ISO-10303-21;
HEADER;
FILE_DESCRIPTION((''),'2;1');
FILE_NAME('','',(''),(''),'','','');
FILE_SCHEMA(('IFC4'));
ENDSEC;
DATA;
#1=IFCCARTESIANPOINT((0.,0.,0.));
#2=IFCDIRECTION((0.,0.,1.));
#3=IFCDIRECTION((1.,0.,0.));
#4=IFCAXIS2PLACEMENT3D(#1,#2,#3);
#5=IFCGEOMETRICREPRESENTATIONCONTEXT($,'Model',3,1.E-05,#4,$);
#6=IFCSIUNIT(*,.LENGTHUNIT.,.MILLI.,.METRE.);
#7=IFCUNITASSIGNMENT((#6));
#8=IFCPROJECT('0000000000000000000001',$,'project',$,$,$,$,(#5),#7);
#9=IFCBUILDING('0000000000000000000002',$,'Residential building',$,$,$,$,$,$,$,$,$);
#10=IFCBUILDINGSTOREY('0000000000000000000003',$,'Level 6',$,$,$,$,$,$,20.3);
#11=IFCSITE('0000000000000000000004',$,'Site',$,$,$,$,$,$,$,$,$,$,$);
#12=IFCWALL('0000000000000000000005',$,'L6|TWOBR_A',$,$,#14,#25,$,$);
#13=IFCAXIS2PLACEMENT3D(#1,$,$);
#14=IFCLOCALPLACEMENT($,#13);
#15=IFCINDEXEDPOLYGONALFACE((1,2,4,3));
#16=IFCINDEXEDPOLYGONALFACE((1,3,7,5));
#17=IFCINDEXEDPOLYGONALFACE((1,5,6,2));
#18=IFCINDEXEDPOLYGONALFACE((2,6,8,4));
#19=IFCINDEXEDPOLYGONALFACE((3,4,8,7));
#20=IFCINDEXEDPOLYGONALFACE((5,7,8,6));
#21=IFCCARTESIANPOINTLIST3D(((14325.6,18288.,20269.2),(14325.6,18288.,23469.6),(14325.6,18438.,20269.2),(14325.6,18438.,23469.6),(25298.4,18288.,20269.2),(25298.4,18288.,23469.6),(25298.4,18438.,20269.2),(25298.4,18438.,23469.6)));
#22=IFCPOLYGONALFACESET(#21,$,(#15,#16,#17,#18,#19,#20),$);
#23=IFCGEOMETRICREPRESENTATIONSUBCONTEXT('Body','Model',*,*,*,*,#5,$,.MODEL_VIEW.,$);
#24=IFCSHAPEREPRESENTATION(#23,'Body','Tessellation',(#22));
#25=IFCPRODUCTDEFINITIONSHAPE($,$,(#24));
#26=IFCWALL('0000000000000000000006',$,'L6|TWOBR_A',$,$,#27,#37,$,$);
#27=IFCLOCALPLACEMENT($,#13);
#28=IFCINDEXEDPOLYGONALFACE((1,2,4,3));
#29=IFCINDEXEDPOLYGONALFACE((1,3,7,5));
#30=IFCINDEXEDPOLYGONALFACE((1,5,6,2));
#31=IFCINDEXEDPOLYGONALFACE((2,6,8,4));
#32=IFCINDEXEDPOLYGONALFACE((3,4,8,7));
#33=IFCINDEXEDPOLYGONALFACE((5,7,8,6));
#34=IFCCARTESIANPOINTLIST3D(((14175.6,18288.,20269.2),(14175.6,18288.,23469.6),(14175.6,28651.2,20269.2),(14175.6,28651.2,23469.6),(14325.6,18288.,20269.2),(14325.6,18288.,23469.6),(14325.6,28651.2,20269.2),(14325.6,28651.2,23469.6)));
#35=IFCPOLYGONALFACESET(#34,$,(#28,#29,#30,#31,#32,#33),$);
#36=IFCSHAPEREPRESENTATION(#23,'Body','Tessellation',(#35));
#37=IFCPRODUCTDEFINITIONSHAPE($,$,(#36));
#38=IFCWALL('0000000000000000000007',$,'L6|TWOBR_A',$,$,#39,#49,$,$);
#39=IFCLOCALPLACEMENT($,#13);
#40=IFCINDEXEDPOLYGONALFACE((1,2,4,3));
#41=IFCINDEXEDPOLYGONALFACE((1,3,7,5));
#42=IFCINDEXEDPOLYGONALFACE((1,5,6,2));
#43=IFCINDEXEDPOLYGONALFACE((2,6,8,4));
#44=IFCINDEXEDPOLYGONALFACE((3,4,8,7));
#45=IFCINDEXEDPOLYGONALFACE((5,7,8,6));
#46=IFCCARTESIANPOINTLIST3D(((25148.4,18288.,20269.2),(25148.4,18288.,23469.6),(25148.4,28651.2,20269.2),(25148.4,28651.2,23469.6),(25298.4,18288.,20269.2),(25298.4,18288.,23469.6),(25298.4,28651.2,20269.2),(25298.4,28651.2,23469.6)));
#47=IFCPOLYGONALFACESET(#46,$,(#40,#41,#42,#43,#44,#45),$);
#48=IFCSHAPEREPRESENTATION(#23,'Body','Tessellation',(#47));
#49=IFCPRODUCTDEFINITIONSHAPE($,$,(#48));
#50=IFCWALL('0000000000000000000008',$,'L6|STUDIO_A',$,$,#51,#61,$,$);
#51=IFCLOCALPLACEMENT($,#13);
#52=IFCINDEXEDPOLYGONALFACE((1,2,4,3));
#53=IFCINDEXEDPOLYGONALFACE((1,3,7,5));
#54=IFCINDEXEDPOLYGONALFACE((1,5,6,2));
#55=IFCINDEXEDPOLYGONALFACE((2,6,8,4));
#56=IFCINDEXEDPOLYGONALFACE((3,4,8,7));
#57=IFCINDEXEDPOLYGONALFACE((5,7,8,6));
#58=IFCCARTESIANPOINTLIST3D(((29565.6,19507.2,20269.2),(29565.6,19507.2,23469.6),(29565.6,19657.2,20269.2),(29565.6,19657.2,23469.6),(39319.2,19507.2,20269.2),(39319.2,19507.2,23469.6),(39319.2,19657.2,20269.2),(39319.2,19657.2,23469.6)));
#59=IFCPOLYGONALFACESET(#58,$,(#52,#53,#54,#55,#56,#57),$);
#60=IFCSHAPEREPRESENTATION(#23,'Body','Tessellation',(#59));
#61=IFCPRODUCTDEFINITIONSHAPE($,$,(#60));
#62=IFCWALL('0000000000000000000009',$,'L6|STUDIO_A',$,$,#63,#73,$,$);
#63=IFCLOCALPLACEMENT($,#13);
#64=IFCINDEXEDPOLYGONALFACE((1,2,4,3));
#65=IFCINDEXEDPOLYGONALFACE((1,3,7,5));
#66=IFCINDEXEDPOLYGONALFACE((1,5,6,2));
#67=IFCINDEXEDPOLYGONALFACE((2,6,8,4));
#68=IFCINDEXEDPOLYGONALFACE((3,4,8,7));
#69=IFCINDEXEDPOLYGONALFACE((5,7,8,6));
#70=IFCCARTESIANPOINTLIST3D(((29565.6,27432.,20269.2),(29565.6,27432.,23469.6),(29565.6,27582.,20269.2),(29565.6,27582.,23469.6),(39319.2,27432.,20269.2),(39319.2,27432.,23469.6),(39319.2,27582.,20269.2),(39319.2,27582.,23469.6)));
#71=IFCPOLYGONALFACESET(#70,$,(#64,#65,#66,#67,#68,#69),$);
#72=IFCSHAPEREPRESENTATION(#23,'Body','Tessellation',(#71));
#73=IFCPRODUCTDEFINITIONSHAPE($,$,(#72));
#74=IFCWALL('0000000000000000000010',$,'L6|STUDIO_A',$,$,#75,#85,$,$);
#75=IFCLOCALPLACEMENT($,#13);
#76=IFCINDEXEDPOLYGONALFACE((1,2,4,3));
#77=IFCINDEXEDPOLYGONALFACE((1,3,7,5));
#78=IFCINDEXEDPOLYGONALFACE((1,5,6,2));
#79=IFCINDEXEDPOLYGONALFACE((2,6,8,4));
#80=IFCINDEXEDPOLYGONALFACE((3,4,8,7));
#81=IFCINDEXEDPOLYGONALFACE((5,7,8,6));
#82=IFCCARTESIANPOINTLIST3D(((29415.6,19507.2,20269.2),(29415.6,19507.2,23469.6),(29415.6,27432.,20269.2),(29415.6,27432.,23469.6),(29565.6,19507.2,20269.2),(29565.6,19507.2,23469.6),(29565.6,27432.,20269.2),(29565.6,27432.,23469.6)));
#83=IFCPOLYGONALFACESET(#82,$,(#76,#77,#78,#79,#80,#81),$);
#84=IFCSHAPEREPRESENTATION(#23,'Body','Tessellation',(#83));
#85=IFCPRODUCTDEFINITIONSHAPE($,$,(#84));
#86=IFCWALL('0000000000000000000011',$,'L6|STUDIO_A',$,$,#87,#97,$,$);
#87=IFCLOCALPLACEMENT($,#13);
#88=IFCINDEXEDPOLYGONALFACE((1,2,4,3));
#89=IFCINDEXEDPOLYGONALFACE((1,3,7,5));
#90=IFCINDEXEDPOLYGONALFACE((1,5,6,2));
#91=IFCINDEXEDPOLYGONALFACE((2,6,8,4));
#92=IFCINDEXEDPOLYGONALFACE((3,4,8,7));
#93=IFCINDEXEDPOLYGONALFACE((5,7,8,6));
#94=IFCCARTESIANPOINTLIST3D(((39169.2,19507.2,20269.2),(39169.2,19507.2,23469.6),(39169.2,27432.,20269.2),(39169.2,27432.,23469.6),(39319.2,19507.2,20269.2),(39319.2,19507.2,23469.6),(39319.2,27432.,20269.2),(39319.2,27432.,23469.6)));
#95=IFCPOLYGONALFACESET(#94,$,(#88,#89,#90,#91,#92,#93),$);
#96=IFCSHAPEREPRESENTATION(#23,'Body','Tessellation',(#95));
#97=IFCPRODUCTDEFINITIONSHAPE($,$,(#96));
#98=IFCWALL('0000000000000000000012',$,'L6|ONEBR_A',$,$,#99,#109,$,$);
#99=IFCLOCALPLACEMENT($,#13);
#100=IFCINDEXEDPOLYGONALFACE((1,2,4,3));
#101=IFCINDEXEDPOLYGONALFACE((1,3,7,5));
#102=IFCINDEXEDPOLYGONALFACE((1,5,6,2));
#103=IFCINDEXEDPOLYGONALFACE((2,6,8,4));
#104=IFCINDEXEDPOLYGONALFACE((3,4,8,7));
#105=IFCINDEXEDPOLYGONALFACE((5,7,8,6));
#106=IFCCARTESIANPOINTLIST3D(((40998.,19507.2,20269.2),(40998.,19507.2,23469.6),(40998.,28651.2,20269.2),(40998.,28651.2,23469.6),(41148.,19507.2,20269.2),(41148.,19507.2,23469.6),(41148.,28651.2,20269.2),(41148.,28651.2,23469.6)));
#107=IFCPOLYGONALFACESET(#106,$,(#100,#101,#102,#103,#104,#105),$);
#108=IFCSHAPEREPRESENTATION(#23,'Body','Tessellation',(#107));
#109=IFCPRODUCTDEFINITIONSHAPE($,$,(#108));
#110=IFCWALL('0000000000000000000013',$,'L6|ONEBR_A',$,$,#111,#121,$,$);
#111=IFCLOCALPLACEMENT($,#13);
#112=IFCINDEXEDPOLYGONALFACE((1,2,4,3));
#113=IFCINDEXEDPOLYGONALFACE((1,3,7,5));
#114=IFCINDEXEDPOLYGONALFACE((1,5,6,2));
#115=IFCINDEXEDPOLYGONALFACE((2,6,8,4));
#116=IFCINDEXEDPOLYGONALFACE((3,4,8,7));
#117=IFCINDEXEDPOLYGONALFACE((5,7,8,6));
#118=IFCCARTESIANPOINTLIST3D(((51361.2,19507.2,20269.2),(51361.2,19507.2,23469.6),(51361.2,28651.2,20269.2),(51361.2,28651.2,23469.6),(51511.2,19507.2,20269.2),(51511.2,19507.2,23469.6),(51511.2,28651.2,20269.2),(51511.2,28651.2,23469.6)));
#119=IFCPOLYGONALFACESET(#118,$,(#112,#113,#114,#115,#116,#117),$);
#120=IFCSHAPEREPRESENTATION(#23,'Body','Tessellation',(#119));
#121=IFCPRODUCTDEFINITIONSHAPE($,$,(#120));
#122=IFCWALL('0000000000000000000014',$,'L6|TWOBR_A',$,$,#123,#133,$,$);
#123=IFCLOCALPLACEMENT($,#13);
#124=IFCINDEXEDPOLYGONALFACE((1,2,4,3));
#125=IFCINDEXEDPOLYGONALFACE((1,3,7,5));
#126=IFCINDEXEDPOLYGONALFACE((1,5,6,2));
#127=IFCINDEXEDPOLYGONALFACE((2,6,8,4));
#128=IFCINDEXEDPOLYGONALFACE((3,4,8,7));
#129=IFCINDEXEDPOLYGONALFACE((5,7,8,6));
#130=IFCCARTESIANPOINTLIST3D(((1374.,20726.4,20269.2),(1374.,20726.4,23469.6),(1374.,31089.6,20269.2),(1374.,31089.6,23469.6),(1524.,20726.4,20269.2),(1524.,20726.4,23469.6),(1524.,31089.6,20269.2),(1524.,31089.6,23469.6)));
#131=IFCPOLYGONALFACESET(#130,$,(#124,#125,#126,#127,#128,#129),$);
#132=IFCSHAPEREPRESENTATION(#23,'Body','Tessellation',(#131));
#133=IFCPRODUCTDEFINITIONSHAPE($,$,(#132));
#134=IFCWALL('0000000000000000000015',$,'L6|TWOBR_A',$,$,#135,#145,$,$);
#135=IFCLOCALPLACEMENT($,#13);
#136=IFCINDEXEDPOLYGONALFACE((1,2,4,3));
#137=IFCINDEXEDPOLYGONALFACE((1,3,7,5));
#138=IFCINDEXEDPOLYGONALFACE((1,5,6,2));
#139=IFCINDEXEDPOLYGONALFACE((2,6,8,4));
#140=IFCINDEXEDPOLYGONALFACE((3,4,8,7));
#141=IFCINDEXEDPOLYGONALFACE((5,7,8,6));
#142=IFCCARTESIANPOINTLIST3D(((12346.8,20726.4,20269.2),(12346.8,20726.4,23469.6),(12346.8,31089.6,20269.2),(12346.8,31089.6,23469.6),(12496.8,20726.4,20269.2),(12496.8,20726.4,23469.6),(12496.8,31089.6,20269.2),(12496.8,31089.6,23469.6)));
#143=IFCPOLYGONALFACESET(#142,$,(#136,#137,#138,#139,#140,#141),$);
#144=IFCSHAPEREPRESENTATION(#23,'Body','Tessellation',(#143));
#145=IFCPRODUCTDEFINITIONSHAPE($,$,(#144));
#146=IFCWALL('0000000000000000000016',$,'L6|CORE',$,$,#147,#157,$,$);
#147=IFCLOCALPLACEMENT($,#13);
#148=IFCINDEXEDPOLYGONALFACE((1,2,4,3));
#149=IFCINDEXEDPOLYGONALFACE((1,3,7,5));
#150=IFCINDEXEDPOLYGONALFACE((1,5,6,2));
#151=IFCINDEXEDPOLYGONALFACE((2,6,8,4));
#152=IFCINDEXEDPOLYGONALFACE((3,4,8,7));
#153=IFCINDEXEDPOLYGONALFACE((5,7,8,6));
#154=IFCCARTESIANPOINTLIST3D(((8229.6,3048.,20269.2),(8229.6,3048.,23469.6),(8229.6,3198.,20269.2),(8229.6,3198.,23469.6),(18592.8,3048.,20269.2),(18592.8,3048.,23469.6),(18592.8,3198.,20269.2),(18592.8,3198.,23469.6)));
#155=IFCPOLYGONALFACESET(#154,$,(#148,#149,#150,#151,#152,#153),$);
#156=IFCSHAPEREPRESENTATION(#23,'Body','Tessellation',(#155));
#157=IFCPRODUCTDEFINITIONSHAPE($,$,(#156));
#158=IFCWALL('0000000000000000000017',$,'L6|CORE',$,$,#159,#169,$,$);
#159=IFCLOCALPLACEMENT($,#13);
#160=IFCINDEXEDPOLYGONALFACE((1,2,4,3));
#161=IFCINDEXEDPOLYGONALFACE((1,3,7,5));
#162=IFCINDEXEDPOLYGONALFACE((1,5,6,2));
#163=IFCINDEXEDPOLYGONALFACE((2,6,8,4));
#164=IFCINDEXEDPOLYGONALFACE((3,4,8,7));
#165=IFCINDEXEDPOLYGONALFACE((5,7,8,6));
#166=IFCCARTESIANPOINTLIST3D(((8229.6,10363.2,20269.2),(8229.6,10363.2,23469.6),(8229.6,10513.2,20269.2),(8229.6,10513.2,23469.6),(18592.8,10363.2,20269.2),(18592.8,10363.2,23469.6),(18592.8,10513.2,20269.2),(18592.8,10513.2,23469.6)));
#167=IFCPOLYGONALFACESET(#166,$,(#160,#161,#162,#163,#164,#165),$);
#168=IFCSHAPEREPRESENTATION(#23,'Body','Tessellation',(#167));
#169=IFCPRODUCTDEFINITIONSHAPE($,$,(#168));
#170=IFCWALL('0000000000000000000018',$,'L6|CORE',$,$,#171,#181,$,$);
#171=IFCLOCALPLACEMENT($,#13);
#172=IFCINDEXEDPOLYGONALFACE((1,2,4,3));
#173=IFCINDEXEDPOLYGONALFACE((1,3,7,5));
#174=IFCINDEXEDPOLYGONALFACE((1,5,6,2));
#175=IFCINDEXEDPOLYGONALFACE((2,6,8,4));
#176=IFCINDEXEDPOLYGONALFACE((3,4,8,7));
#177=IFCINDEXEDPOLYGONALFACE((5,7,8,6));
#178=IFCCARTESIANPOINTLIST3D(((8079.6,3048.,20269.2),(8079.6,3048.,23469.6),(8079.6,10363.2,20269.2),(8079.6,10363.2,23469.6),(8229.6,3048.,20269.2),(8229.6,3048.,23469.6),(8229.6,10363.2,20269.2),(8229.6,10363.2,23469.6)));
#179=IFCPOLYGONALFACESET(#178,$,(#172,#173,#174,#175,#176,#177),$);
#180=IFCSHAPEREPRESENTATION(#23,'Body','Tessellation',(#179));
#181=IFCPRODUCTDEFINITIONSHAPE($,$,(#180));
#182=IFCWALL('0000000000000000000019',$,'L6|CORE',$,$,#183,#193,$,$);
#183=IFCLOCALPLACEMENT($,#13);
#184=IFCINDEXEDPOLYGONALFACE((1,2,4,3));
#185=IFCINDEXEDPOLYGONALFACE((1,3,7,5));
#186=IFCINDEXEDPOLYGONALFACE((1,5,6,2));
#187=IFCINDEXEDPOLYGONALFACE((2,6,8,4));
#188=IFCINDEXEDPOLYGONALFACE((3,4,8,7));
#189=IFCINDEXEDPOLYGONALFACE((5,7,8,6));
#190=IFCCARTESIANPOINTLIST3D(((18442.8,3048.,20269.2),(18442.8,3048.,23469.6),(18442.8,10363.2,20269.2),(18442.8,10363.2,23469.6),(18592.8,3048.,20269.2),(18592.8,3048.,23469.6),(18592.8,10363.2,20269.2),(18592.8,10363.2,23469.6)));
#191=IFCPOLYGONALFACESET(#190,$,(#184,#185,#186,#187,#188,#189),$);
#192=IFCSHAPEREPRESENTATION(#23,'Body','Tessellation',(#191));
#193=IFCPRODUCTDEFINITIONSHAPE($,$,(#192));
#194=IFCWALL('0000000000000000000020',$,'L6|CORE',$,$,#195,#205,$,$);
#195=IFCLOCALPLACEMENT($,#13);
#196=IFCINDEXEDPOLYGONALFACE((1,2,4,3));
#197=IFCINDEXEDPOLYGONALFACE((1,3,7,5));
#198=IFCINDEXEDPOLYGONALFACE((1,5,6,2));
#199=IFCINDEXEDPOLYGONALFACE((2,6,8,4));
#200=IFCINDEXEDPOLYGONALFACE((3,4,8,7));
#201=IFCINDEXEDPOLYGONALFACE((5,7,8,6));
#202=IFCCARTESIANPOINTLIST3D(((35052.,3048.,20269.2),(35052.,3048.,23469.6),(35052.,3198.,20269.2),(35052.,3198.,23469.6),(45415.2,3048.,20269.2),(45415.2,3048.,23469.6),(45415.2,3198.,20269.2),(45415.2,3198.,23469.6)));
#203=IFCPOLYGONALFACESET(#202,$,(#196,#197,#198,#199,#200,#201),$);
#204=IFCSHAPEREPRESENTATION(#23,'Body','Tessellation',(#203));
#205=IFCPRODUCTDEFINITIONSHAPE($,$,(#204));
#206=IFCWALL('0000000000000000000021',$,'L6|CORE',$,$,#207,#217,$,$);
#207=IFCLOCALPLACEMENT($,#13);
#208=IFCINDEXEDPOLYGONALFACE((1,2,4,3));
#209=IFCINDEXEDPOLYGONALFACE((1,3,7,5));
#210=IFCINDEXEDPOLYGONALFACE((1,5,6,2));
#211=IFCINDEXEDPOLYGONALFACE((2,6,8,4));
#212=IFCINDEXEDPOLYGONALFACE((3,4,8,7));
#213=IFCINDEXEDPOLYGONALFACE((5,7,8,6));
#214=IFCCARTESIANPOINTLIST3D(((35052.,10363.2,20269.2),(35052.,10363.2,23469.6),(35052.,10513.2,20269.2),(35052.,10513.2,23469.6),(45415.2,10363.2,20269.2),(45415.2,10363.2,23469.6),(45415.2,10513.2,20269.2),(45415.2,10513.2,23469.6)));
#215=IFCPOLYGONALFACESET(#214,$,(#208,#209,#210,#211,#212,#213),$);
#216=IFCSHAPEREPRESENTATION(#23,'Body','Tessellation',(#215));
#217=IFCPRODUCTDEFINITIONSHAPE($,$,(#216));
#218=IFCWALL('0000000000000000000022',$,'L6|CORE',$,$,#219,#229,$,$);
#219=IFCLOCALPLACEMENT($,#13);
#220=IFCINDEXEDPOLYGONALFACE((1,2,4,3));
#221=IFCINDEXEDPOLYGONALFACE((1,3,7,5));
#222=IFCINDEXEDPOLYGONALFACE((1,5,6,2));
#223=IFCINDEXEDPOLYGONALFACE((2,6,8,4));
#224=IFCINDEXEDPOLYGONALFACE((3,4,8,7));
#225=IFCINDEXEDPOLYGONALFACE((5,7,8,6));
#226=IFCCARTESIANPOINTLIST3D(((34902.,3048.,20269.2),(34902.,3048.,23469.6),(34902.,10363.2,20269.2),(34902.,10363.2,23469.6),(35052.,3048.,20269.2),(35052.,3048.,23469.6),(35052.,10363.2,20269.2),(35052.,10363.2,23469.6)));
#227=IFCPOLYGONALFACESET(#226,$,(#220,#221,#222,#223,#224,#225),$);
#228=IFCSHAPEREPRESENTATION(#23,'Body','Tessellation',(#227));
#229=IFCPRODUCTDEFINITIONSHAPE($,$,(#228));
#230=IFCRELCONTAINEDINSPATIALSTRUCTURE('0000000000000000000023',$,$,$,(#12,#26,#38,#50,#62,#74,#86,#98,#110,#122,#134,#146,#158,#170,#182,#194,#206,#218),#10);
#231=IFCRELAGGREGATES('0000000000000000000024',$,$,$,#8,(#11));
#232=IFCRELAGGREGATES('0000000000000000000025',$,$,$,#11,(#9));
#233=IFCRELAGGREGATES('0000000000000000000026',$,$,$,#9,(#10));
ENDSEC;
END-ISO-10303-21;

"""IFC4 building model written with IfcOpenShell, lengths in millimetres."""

from ifc_helpers import new_model, si_unit, frame, origin_with_axes, place, context, subcontext, project, spatial, indexed_curve, outline, extrude, element, save


model = new_model("IFC4")

# Units and contexts
model_context = context("Model", 3, precision=1e-05, world=origin_with_axes())
body_context = subcontext(model_context, "Body", "Model", "MODEL_VIEW")
ifc_project = project(units=[si_unit("LENGTHUNIT", "METRE", prefix="MILLI")], contexts=[model_context])

# Site, building, storey
site = spatial("IfcSite", under=ifc_project, Name="Site")
building = spatial("IfcBuilding", under=site, Name="Residential building")
storey = spatial("IfcBuildingStorey", under=building, Name="Level 6", Elevation=20.3)

# Walls
wall_1_placement = place(None, frame((14325.6, 18288.0, 20269.2), z_axis=(0.0, 0.0, 1.0), x_axis=(1.0, 0.0, 0.0)))
element("IfcWall", 1, at=wall_1_placement, inside=storey, Name="L6|TWOBR_A", context=body_context, shape_type="SweptSolid", body=[
    extrude(outline(indexed_curve([(0.0, 0.0), (0.0, 150.0), (10972.8, 150.0), (10972.8, 0.0), (0.0, 0.0)], self_intersect=False)), origin_with_axes(), (0.0, 0.0, 1.0), 3200.4),
])
for number, where, z_axis, x_axis, name in (
    (2, (14325.6, 18288.0, 20269.2), (0.0, 0.0, 1.0), (0.0, 1.0, 0.0), "L6|TWOBR_A"),
    (3, (25298.4, 18288.0, 20269.2), (0.0, 0.0, 1.0), (0.0, 1.0, 0.0), "L6|TWOBR_A"),
):
    element("IfcWall", number, at=place(None, frame(where, z_axis=z_axis, x_axis=x_axis)), inside=storey, Name=name, context=body_context, shape_type="SweptSolid", body=[
        extrude(outline(indexed_curve([(0.0, 0.0), (0.0, 150.0), (10363.2, 150.0), (10363.2, 0.0), (0.0, 0.0)], self_intersect=False)), origin_with_axes(), (0.0, 0.0, 1.0), 3200.4),
    ])
for number, where, z_axis, x_axis, name in (
    (4, (29565.6, 19507.2, 20269.2), (0.0, 0.0, 1.0), (1.0, 0.0, 0.0), "L6|STUDIO_A"),
    (5, (29565.6, 27432.0, 20269.2), (0.0, 0.0, 1.0), (1.0, 0.0, 0.0), "L6|STUDIO_A"),
):
    element("IfcWall", number, at=place(None, frame(where, z_axis=z_axis, x_axis=x_axis)), inside=storey, Name=name, context=body_context, shape_type="SweptSolid", body=[
        extrude(outline(indexed_curve([(0.0, 0.0), (0.0, 150.0), (9753.6, 150.0), (9753.6, 0.0), (0.0, 0.0)], self_intersect=False)), origin_with_axes(), (0.0, 0.0, 1.0), 3200.4),
    ])
for number, where, z_axis, x_axis, name in (
    (6, (29565.6, 19507.2, 20269.2), (0.0, 0.0, 1.0), (0.0, 1.0, 0.0), "L6|STUDIO_A"),
    (7, (39319.2, 19507.2, 20269.2), (0.0, 0.0, 1.0), (0.0, 1.0, 0.0), "L6|STUDIO_A"),
):
    element("IfcWall", number, at=place(None, frame(where, z_axis=z_axis, x_axis=x_axis)), inside=storey, Name=name, context=body_context, shape_type="SweptSolid", body=[
        extrude(outline(indexed_curve([(0.0, 0.0), (0.0, 150.0), (7924.8, 150.0), (7924.8, 0.0), (0.0, 0.0)], self_intersect=False)), origin_with_axes(), (0.0, 0.0, 1.0), 3200.4),
    ])
for number, where, z_axis, x_axis, name in (
    (8, (41148.0, 19507.2, 20269.2), (0.0, 0.0, 1.0), (0.0, 1.0, 0.0), "L6|ONEBR_A"),
    (9, (51511.2, 19507.2, 20269.2), (0.0, 0.0, 1.0), (0.0, 1.0, 0.0), "L6|ONEBR_A"),
):
    element("IfcWall", number, at=place(None, frame(where, z_axis=z_axis, x_axis=x_axis)), inside=storey, Name=name, context=body_context, shape_type="SweptSolid", body=[
        extrude(outline(indexed_curve([(0.0, 0.0), (0.0, 150.0), (9144.0, 150.0), (9144.0, 0.0), (0.0, 0.0)], self_intersect=False)), origin_with_axes(), (0.0, 0.0, 1.0), 3200.4),
    ])
for number, where, z_axis, x_axis, name in (
    (10, (1524.0, 20726.4, 20269.2), (0.0, 0.0, 1.0), (0.0, 1.0, 0.0), "L6|TWOBR_A"),
    (11, (12496.8, 20726.4, 20269.2), (0.0, 0.0, 1.0), (0.0, 1.0, 0.0), "L6|TWOBR_A"),
    (12, (8229.6, 3048.0, 20269.2), (0.0, 0.0, 1.0), (1.0, 0.0, 0.0), "L6|CORE"),
    (13, (8229.6, 10363.2, 20269.2), (0.0, 0.0, 1.0), (1.0, 0.0, 0.0), "L6|CORE"),
):
    element("IfcWall", number, at=place(None, frame(where, z_axis=z_axis, x_axis=x_axis)), inside=storey, Name=name, context=body_context, shape_type="SweptSolid", body=[
        extrude(outline(indexed_curve([(0.0, 0.0), (0.0, 150.0), (10363.2, 150.0), (10363.2, 0.0), (0.0, 0.0)], self_intersect=False)), origin_with_axes(), (0.0, 0.0, 1.0), 3200.4),
    ])
for number, where, z_axis, x_axis, name in (
    (14, (8229.6, 3048.0, 20269.2), (0.0, 0.0, 1.0), (0.0, 1.0, 0.0), "L6|CORE"),
    (15, (18592.8, 3048.0, 20269.2), (0.0, 0.0, 1.0), (0.0, 1.0, 0.0), "L6|CORE"),
):
    element("IfcWall", number, at=place(None, frame(where, z_axis=z_axis, x_axis=x_axis)), inside=storey, Name=name, context=body_context, shape_type="SweptSolid", body=[
        extrude(outline(indexed_curve([(0.0, 0.0), (0.0, 150.0), (7315.2, 150.0), (7315.2, 0.0), (0.0, 0.0)], self_intersect=False)), origin_with_axes(), (0.0, 0.0, 1.0), 3200.4),
    ])
for number, where, z_axis, x_axis, name in (
    (16, (35052.0, 3048.0, 20269.2), (0.0, 0.0, 1.0), (1.0, 0.0, 0.0), "L6|CORE"),
    (17, (35052.0, 10363.2, 20269.2), (0.0, 0.0, 1.0), (1.0, 0.0, 0.0), "L6|CORE"),
):
    element("IfcWall", number, at=place(None, frame(where, z_axis=z_axis, x_axis=x_axis)), inside=storey, Name=name, context=body_context, shape_type="SweptSolid", body=[
        extrude(outline(indexed_curve([(0.0, 0.0), (0.0, 150.0), (10363.2, 150.0), (10363.2, 0.0), (0.0, 0.0)], self_intersect=False)), origin_with_axes(), (0.0, 0.0, 1.0), 3200.4),
    ])
for number, where, z_axis, x_axis, name in (
    (18, (35052.0, 3048.0, 20269.2), (0.0, 0.0, 1.0), (0.0, 1.0, 0.0), "L6|CORE"),
):
    element("IfcWall", number, at=place(None, frame(where, z_axis=z_axis, x_axis=x_axis)), inside=storey, Name=name, context=body_context, shape_type="SweptSolid", body=[
        extrude(outline(indexed_curve([(0.0, 0.0), (0.0, 150.0), (7315.2, 150.0), (7315.2, 0.0), (0.0, 0.0)], self_intersect=False)), origin_with_axes(), (0.0, 0.0, 1.0), 3200.4),
    ])

save(model, "model.ifc")
